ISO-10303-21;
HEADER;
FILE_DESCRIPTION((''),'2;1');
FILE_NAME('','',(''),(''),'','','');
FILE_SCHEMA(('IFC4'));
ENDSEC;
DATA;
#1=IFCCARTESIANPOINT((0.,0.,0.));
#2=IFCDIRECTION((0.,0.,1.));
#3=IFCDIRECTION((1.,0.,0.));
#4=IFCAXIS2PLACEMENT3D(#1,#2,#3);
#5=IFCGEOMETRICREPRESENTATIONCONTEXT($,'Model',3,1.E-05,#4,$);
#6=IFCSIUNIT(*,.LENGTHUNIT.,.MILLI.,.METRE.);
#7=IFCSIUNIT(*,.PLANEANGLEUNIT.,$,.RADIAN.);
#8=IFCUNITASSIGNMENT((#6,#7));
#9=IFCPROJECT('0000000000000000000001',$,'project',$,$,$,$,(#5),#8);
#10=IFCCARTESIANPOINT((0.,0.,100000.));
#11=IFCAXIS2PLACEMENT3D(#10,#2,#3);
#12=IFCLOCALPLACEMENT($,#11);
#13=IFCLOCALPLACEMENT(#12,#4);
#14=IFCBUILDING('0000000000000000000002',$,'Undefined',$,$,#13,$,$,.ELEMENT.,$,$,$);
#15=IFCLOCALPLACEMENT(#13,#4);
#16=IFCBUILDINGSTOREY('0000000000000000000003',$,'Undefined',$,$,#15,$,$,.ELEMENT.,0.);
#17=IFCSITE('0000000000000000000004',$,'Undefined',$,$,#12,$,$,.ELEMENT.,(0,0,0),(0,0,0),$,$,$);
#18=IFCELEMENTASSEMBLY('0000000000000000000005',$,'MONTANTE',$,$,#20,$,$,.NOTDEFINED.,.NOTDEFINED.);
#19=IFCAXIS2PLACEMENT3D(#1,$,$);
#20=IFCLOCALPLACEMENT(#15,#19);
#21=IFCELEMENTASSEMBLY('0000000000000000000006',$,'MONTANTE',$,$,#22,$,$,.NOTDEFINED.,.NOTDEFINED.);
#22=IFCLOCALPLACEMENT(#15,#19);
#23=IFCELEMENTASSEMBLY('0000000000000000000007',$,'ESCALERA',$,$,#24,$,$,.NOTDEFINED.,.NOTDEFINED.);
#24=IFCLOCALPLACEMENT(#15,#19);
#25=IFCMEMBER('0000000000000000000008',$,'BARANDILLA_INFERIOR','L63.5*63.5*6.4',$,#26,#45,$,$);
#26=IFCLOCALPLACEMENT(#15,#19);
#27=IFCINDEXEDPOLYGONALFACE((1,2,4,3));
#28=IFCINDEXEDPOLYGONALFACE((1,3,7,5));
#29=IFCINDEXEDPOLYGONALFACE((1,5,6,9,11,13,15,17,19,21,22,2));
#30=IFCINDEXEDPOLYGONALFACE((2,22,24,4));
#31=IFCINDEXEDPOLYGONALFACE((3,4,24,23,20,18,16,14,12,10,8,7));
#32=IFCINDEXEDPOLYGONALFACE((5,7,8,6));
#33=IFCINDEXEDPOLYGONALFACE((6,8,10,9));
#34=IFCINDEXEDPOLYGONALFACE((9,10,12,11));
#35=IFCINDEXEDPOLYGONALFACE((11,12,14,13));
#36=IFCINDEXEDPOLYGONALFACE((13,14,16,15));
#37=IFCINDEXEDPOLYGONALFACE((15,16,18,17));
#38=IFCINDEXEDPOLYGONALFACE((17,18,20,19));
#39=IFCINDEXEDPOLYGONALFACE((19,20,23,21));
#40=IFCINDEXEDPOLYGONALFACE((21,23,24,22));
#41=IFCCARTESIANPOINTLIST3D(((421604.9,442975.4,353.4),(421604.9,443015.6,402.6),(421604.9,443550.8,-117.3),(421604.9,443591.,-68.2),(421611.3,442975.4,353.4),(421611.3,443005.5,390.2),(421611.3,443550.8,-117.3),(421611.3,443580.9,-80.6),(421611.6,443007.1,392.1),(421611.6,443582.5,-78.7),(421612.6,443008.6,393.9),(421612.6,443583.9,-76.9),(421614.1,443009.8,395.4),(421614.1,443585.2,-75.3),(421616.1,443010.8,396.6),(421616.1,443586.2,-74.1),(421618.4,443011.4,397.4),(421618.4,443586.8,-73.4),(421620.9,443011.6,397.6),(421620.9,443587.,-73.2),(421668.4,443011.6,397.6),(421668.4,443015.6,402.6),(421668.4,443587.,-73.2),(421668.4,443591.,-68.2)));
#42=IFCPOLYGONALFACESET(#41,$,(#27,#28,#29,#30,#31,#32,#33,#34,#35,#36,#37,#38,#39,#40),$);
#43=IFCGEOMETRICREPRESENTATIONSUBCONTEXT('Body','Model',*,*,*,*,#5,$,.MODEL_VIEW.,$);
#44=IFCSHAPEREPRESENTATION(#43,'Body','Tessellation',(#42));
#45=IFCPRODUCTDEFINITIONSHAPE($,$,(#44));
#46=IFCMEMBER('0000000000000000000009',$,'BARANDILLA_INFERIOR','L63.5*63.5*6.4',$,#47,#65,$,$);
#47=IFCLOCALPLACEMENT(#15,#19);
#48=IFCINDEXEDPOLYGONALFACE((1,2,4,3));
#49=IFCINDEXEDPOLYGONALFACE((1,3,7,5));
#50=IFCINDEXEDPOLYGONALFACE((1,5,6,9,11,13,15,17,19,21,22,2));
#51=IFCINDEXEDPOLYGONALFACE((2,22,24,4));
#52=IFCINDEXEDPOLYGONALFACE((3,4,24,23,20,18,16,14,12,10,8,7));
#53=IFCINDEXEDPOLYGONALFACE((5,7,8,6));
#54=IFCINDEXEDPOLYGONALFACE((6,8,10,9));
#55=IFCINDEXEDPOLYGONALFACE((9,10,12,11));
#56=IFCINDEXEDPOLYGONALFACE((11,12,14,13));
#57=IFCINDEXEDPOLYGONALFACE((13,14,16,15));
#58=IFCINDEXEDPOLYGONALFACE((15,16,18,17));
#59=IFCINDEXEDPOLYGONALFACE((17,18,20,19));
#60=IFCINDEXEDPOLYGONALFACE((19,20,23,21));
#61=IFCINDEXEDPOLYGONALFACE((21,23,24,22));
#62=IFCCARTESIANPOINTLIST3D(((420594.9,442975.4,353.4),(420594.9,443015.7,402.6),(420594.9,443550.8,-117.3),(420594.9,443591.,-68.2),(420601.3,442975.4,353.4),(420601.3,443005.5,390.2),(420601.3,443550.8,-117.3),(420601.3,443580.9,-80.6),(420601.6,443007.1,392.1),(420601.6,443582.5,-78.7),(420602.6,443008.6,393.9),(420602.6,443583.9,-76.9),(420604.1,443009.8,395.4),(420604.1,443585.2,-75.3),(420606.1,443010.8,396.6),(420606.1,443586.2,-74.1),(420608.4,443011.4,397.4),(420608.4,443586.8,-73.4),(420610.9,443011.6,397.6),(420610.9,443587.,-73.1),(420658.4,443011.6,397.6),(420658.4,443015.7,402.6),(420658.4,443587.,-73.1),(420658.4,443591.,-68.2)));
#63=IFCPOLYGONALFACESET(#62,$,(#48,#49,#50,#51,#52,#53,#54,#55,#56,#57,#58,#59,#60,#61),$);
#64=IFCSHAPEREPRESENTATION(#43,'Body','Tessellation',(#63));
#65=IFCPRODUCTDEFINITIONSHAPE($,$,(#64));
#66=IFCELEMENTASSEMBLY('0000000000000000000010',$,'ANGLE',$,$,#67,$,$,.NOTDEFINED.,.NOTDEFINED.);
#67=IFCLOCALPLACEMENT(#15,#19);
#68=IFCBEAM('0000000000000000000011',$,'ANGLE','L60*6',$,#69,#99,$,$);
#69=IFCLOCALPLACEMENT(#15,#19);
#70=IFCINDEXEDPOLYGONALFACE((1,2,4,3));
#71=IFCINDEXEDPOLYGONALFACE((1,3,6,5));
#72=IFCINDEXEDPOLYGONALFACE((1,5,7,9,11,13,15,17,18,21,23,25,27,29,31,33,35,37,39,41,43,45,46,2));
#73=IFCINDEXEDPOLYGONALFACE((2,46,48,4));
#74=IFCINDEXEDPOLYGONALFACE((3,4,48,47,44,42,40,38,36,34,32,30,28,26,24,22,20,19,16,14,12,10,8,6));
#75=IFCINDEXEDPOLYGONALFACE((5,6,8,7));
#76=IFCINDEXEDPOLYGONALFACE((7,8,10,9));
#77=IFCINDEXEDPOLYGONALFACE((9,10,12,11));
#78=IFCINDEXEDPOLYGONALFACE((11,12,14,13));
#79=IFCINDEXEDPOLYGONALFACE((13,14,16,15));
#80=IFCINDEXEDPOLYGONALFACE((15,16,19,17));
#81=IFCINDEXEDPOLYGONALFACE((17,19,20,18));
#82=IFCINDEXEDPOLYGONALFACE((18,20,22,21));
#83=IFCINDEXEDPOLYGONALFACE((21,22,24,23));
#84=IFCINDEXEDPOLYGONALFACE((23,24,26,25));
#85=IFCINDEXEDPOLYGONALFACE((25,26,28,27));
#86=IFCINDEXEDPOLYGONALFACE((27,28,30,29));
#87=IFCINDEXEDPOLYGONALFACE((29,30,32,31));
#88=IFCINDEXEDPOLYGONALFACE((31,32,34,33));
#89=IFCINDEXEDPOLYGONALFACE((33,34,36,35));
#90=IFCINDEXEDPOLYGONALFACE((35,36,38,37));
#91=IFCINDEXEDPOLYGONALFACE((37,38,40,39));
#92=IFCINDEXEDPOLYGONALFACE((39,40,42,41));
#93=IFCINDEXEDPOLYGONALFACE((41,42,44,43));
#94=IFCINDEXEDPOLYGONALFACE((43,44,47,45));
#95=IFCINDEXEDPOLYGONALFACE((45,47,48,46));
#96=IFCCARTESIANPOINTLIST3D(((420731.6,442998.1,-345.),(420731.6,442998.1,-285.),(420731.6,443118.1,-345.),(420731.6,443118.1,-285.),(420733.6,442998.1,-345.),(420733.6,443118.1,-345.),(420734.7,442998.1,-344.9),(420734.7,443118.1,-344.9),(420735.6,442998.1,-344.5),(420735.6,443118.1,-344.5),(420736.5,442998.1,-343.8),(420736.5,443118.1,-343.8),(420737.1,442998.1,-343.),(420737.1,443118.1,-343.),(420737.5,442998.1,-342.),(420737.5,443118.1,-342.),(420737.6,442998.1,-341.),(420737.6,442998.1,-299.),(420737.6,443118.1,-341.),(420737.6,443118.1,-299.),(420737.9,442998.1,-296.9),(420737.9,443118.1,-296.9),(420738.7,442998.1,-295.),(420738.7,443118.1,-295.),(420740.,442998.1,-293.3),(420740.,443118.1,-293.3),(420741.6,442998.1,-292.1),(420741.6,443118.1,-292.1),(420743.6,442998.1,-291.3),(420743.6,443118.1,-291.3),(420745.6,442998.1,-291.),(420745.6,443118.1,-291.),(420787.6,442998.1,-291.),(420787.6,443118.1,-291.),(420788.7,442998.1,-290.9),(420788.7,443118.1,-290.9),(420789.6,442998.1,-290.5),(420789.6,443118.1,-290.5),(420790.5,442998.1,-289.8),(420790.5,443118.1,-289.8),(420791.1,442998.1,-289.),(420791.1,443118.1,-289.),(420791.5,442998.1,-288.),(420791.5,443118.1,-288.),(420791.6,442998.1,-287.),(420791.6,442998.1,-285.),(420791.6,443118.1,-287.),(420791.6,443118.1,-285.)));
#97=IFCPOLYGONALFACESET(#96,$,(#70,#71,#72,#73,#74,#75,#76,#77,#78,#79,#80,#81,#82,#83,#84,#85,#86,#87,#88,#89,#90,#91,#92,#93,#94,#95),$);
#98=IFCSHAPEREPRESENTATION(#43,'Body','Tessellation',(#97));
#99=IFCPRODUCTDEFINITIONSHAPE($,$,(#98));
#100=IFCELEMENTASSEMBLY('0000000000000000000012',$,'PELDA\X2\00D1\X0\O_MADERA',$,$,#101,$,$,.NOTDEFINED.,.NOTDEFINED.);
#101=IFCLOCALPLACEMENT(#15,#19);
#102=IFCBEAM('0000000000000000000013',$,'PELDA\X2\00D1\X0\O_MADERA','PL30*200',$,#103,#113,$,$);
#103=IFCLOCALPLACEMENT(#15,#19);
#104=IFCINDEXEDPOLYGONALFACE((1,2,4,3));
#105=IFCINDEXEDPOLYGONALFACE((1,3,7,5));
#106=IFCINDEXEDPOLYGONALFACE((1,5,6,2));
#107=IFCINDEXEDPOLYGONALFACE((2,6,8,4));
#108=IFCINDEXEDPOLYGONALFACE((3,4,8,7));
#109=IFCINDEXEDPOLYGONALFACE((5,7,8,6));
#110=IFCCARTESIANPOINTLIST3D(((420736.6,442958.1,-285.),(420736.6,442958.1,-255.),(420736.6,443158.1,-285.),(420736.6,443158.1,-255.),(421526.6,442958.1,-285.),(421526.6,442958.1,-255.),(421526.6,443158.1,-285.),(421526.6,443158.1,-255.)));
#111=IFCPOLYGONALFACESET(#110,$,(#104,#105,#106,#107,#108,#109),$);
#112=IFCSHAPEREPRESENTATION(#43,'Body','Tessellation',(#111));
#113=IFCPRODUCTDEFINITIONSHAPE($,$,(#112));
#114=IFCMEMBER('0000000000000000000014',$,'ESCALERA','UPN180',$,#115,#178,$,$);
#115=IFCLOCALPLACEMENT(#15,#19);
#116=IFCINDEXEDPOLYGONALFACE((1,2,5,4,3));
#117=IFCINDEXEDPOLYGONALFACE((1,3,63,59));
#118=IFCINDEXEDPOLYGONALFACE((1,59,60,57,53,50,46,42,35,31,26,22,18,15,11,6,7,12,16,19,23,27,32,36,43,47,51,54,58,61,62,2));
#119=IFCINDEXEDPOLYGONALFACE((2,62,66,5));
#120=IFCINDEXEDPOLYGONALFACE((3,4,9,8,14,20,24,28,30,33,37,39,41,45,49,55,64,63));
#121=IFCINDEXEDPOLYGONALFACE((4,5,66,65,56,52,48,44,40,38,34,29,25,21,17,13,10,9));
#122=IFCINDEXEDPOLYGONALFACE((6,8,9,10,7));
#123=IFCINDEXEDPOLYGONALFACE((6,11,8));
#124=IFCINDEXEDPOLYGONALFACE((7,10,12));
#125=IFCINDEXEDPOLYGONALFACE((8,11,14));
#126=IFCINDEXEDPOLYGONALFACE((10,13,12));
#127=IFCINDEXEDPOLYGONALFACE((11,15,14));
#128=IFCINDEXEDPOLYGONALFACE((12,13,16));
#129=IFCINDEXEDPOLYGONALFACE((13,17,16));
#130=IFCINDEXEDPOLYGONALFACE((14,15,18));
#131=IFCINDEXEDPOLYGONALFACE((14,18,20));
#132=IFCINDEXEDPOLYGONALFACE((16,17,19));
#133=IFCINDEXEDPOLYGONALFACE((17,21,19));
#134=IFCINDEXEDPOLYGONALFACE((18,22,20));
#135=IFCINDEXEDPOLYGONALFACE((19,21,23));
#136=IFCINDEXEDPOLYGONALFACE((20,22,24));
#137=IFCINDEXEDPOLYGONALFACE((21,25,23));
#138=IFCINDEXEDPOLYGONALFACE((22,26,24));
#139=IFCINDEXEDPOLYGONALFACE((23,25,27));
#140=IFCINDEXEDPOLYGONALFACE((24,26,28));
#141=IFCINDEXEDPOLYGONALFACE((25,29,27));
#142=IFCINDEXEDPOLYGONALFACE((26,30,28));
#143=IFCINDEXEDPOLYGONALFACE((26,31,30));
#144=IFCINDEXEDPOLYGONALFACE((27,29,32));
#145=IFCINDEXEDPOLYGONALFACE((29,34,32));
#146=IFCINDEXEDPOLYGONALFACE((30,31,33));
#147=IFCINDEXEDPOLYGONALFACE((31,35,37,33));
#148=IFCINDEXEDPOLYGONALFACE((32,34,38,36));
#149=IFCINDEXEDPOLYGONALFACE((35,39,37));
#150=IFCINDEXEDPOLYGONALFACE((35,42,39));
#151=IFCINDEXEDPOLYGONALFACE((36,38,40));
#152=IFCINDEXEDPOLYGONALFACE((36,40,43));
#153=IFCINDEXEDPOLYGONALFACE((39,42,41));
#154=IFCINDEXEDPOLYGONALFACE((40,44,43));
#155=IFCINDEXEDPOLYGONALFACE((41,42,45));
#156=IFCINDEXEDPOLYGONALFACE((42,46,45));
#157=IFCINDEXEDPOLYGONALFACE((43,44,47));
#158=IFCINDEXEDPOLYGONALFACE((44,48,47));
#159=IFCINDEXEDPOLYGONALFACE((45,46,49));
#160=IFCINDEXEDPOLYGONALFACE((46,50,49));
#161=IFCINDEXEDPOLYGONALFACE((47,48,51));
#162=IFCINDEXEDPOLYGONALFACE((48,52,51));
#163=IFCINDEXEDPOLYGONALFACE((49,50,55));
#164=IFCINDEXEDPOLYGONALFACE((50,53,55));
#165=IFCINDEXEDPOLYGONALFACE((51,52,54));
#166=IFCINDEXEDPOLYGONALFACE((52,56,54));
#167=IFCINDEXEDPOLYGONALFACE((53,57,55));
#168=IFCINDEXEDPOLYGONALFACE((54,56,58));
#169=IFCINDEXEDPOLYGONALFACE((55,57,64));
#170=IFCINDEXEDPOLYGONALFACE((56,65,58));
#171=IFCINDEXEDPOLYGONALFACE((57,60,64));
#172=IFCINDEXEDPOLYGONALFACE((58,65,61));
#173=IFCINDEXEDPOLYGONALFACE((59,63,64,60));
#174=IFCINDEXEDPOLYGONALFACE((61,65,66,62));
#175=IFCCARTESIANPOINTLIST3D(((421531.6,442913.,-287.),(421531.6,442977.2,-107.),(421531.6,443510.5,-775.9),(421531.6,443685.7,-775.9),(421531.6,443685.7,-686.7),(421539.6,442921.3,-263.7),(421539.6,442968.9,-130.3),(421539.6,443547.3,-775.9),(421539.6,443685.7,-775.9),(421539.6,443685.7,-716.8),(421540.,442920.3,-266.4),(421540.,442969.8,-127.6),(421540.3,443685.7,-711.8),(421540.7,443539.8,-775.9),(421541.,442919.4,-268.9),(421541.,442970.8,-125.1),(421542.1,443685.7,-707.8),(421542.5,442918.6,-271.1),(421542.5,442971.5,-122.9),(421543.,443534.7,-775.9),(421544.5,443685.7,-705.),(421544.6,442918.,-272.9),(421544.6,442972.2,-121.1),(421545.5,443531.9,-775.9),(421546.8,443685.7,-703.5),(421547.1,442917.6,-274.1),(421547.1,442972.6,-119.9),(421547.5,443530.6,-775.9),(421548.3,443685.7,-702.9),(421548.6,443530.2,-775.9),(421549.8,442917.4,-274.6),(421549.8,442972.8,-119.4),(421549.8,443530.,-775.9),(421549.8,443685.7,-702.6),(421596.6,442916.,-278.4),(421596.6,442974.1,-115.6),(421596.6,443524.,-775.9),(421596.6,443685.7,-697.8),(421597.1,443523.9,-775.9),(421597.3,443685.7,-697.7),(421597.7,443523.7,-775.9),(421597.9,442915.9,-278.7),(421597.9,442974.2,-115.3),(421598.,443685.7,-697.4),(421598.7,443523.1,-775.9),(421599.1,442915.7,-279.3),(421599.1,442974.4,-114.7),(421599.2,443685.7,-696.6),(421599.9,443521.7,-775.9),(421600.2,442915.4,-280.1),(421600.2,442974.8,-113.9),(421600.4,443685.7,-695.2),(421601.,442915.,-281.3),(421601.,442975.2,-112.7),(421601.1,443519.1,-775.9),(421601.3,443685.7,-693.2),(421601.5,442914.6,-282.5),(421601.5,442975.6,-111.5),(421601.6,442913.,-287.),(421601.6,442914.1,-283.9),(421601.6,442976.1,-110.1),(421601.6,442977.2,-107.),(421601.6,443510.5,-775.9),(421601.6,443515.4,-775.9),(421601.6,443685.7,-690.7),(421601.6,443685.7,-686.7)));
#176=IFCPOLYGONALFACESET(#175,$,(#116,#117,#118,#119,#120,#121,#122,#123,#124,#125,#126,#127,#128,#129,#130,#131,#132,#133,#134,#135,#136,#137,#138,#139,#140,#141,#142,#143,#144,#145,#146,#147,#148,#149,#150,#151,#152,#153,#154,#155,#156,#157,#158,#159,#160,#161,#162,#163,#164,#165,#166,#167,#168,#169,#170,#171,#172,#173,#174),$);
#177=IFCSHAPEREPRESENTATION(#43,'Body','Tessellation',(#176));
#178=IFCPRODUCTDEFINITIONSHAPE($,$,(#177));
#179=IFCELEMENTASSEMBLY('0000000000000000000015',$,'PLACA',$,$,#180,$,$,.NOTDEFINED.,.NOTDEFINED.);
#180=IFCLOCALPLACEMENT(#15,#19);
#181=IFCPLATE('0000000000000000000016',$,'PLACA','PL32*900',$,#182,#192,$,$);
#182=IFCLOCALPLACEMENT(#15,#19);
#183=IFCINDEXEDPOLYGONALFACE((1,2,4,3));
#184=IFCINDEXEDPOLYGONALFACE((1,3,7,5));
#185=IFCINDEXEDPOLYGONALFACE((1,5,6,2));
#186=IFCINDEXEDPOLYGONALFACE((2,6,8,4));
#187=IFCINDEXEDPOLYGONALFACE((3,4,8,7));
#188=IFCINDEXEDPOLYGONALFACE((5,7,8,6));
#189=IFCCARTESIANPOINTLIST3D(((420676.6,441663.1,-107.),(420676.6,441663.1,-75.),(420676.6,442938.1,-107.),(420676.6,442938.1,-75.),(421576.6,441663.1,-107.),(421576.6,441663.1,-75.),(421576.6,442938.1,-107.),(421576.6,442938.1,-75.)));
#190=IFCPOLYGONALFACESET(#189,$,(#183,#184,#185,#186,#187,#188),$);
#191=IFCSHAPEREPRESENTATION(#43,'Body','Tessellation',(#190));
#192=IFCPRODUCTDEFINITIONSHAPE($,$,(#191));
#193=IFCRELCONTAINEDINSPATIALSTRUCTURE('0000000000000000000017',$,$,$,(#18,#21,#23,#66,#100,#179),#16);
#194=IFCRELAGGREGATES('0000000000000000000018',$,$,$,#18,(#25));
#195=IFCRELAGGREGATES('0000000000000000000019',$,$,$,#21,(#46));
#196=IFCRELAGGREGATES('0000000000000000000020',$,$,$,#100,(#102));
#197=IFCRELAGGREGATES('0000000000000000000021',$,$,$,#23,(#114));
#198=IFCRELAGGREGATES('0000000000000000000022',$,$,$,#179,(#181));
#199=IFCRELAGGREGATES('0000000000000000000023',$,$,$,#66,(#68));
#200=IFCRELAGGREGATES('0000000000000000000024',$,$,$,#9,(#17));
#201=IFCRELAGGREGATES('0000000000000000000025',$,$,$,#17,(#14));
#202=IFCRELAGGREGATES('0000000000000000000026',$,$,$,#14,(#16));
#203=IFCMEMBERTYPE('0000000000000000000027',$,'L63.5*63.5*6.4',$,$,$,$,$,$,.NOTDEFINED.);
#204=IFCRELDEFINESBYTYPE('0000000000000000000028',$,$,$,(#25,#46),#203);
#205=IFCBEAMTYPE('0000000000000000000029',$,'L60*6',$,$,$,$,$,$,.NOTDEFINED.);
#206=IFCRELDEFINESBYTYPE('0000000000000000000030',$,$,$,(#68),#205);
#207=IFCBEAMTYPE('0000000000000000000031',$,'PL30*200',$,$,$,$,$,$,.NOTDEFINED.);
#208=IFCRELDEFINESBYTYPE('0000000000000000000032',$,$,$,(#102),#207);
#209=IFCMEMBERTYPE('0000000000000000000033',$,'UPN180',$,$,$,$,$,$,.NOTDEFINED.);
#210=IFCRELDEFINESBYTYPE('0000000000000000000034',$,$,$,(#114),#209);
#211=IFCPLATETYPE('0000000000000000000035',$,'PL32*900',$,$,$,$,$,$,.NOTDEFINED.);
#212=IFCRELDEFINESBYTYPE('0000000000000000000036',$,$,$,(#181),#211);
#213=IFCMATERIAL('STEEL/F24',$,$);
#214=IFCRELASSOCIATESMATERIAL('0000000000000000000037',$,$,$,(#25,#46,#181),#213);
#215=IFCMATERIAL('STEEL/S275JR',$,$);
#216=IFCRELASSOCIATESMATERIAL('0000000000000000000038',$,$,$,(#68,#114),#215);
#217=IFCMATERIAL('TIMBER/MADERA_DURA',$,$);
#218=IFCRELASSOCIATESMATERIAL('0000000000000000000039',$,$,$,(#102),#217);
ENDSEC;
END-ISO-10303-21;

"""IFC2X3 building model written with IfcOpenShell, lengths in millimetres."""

from ifc_helpers import new_model, si_unit, frame, origin_with_axes, origin_2d_with_axis, place, context, subcontext, project, spatial, polyline, rectangle, l_section, u_section, outline, extrude, clip, halfspace, material, type_object, element, aggregate, save


model = new_model("IFC2X3")

# Units and contexts
model_context = context("Model", 3, precision=1e-05, world=origin_with_axes())
body_context = subcontext(model_context, "Body", "Model", "MODEL_VIEW")
ifc_project = project(units=[si_unit("LENGTHUNIT", "METRE", prefix="MILLI"), si_unit("PLANEANGLEUNIT", "RADIAN")], contexts=[model_context])

# Site, building, storey
site_placement = place(None, frame((0.0, 0.0, 100000.0), z_axis=(0.0, 0.0, 1.0), x_axis=(1.0, 0.0, 0.0)))
site = spatial("IfcSite", under=ifc_project, at=site_placement, Name="Undefined", CompositionType="ELEMENT", RefLatitude=(0, 0, 0), RefLongitude=(0, 0, 0))
building_placement = place(site_placement, origin_with_axes())
building = spatial("IfcBuilding", under=site, at=building_placement, Name="Undefined", CompositionType="ELEMENT")
storey_placement = place(building_placement, origin_with_axes())
storey = spatial("IfcBuildingStorey", under=building, at=storey_placement, Name="Undefined", CompositionType="ELEMENT", Elevation=0.0)

# Shared definitions
ifc_material_1 = material(Name="STEEL/F24")

# Element assemblies
assembly_1_placement = place(storey_placement, origin_with_axes())
assembly_1 = element("IfcElementAssembly", 1, at=assembly_1_placement, inside=storey, Name="MONTANTE", AssemblyPlace="NOTDEFINED", PredefinedType="NOTDEFINED")
assembly_2_placement = place(storey_placement, origin_with_axes())
assembly_2 = element("IfcElementAssembly", 2, at=assembly_2_placement, inside=storey, Name="MONTANTE", AssemblyPlace="NOTDEFINED", PredefinedType="NOTDEFINED")

# Shared definitions
ifc_material_2 = material(Name="STEEL/S275JR")

# Element assembly
assembly_3_placement = place(storey_placement, origin_with_axes())
assembly_3 = element("IfcElementAssembly", 3, at=assembly_3_placement, inside=storey, Name="ESCALERA", AssemblyPlace="NOTDEFINED", PredefinedType="NOTDEFINED")

# Members
member_type_1 = type_object("IfcMemberType", Name="L63.5*63.5*6.4", PredefinedType="NOTDEFINED")
member_1_placement = place(assembly_1_placement, frame((421636.6, 442995.5, 378.0), z_axis=(1.0, 0.000001, 0.0), x_axis=(-0.000001, 0.773957, -0.633238)))
member_1 = element("IfcMember", 4, at=member_1_placement, type_object=member_type_1, material=ifc_material_1, Name="BARANDILLA_INFERIOR", Description="L63.5*63.5*6.4", context=body_context, shape_type="SweptSolid", body=[
    extrude(l_section(Depth=63.5, Width=63.5, Thickness=6.4, FilletRadius=9.6, at=origin_2d_with_axis()), frame((743.4, 0.0, 0.0), z_axis=(-1.0, 0.0, 0.0), x_axis=(0.0, -1.0, 0.0)), (0.0, 0.0, 1.0), 743.4),
])
aggregate(assembly_1, [member_1])
member_2_placement = place(assembly_2_placement, frame((420626.6, 442995.5, 378.0), z_axis=(1.0, 0.000001, 0.0), x_axis=(-0.000001, 0.773957, -0.633238)))
member_2 = element("IfcMember", 5, at=member_2_placement, type_object=member_type_1, material=ifc_material_1, Name="BARANDILLA_INFERIOR", Description="L63.5*63.5*6.4", context=body_context, shape_type="SweptSolid", body=[
    extrude(l_section(Depth=63.5, Width=63.5, Thickness=6.4, FilletRadius=9.6, at=origin_2d_with_axis()), frame((743.4, 0.0, 0.0), z_axis=(-1.0, 0.0, 0.0), x_axis=(0.0, -1.0, 0.0)), (0.0, 0.0, 1.0), 743.4),
])
aggregate(assembly_2, [member_2])

# Element assemblies, beams
assembly_4_placement = place(storey_placement, origin_with_axes())
assembly_4 = element("IfcElementAssembly", 6, at=assembly_4_placement, inside=storey, Name="ANGLE", AssemblyPlace="NOTDEFINED", PredefinedType="NOTDEFINED")
beam_type_1 = type_object("IfcBeamType", Name="L60*6", PredefinedType="NOTDEFINED")
beam_1_placement = place(assembly_4_placement, frame((420761.6, 442998.1, -315.0), z_axis=(1.0, 0.000001, 0.0), x_axis=(-0.000001, 1.0, 0.0)))
beam_1 = element("IfcBeam", 7, at=beam_1_placement, type_object=beam_type_1, material=ifc_material_2, Name="ANGLE", Description="L60*6", context=body_context, shape_type="SweptSolid", body=[
    extrude(l_section(Depth=60.0, Width=60.0, Thickness=6.0, FilletRadius=8.0, EdgeRadius=4.0, at=origin_2d_with_axis()), frame((120.0, 0.0, 0.0), z_axis=(-1.0, 0.0, 0.0), x_axis=(0.0, -1.0, 0.0)), (0.0, 0.0, 1.0), 120.0),
])
assembly_5_placement = place(storey_placement, origin_with_axes())
assembly_5 = element("IfcElementAssembly", 8, at=assembly_5_placement, inside=storey, Name="PELDAÑO_MADERA", AssemblyPlace="NOTDEFINED", PredefinedType="NOTDEFINED")
ifc_material_3 = material(Name="TIMBER/MADERA_DURA")
beam_type_2 = type_object("IfcBeamType", Name="PL30*200", PredefinedType="NOTDEFINED")
beam_2_placement = place(assembly_5_placement, frame((420736.6, 443058.1, -270.0), z_axis=(0.000001, -1.0, 0.0), x_axis=(1.0, 0.000001, 0.0)))
beam_2 = element("IfcBeam", 9, at=beam_2_placement, type_object=beam_type_2, material=ifc_material_3, Name="PELDAÑO_MADERA", Description="PL30*200", context=body_context, shape_type="SweptSolid", body=[
    extrude(rectangle(XDim=30.0, YDim=200.0, at=origin_2d_with_axis()), frame((790.0, 0.0, 0.0), z_axis=(-1.0, 0.0, 0.0), x_axis=(0.0, -1.0, 0.0)), (0.0, 0.0, 1.0), 790.0),
])
aggregate(assembly_5, [beam_2])

# Member
member_type_2 = type_object("IfcMemberType", Name="UPN180", PredefinedType="NOTDEFINED")
member_3_placement = place(assembly_3_placement, frame((421566.6, 442920.2, -176.7), z_axis=(-0.000001, 0.633238, 0.773957), x_axis=(-0.000001, 0.773957, -0.633238)))
member_3 = element("IfcMember", 10, at=member_3_placement, type_object=member_type_2, material=ifc_material_2, Name="ESCALERA", Description="UPN180", context=body_context, shape_type="Clipping", body=[
    clip(clip(clip(extrude(u_section(Depth=180.0, FlangeWidth=70.0, WebThickness=8.0, FlangeThickness=11.0, FilletRadius=11.0, EdgeRadius=5.5, FlangeSlope=0.07983, at=origin_2d_with_axis()), frame((1054.8, 0.0, 0.0), z_axis=(-1.0, 0.0, 0.0), x_axis=(0.0, -1.0, 0.0)), (0.0, 0.0, 1.0), 1131.3), halfspace(frame((1062.7, -35.0, -90.0), z_axis=(0.773957, 0.0, 0.633238), x_axis=(-0.633238, 0.0, 0.773957)), False)), halfspace(frame((894.5, 1035.0, -42.3), z_axis=(-0.633238, 0.0, 0.773957), x_axis=(0.773957, 0.0, 0.633238)), True)), halfspace(frame((0.0, -35.0, 90.0), z_axis=(-0.941795, 0.0, -0.336186), x_axis=(0.0, -1.0, 0.0)), False)),
])
aggregate(assembly_3, [member_3])

# Element assembly, plate
assembly_6_placement = place(storey_placement, origin_with_axes())
assembly_6 = element("IfcElementAssembly", 11, at=assembly_6_placement, inside=storey, Name="PLACA", AssemblyPlace="NOTDEFINED", PredefinedType="NOTDEFINED")
plate_type = type_object("IfcPlateType", Name="PL32*900", PredefinedType="NOTDEFINED")
plate_placement = place(assembly_6_placement, frame((421576.6, 442938.1, -91.0), z_axis=(0.0, 0.0, 1.0), x_axis=(-1.0, 0.0, 0.0)))
plate = element("IfcPlate", 12, at=plate_placement, type_object=plate_type, material=ifc_material_1, Name="PLACA", Description="PL32*900", context=body_context, shape_type="SweptSolid", body=[
    extrude(outline(polyline([(0.0, 0.0), (900.0, 0.0), (900.0, 1275.0), (0.0, 1275.0), (0.0, 0.0)])), frame((0.0, 0.0, -16.0), z_axis=(0.0, 0.0, 1.0), x_axis=(1.0, 0.0, 0.0)), (0.0, 0.0, 1.0), 32.0),
])
aggregate(assembly_6, [plate])

aggregate(assembly_4, [beam_1])

save(model, "model.ifc")
